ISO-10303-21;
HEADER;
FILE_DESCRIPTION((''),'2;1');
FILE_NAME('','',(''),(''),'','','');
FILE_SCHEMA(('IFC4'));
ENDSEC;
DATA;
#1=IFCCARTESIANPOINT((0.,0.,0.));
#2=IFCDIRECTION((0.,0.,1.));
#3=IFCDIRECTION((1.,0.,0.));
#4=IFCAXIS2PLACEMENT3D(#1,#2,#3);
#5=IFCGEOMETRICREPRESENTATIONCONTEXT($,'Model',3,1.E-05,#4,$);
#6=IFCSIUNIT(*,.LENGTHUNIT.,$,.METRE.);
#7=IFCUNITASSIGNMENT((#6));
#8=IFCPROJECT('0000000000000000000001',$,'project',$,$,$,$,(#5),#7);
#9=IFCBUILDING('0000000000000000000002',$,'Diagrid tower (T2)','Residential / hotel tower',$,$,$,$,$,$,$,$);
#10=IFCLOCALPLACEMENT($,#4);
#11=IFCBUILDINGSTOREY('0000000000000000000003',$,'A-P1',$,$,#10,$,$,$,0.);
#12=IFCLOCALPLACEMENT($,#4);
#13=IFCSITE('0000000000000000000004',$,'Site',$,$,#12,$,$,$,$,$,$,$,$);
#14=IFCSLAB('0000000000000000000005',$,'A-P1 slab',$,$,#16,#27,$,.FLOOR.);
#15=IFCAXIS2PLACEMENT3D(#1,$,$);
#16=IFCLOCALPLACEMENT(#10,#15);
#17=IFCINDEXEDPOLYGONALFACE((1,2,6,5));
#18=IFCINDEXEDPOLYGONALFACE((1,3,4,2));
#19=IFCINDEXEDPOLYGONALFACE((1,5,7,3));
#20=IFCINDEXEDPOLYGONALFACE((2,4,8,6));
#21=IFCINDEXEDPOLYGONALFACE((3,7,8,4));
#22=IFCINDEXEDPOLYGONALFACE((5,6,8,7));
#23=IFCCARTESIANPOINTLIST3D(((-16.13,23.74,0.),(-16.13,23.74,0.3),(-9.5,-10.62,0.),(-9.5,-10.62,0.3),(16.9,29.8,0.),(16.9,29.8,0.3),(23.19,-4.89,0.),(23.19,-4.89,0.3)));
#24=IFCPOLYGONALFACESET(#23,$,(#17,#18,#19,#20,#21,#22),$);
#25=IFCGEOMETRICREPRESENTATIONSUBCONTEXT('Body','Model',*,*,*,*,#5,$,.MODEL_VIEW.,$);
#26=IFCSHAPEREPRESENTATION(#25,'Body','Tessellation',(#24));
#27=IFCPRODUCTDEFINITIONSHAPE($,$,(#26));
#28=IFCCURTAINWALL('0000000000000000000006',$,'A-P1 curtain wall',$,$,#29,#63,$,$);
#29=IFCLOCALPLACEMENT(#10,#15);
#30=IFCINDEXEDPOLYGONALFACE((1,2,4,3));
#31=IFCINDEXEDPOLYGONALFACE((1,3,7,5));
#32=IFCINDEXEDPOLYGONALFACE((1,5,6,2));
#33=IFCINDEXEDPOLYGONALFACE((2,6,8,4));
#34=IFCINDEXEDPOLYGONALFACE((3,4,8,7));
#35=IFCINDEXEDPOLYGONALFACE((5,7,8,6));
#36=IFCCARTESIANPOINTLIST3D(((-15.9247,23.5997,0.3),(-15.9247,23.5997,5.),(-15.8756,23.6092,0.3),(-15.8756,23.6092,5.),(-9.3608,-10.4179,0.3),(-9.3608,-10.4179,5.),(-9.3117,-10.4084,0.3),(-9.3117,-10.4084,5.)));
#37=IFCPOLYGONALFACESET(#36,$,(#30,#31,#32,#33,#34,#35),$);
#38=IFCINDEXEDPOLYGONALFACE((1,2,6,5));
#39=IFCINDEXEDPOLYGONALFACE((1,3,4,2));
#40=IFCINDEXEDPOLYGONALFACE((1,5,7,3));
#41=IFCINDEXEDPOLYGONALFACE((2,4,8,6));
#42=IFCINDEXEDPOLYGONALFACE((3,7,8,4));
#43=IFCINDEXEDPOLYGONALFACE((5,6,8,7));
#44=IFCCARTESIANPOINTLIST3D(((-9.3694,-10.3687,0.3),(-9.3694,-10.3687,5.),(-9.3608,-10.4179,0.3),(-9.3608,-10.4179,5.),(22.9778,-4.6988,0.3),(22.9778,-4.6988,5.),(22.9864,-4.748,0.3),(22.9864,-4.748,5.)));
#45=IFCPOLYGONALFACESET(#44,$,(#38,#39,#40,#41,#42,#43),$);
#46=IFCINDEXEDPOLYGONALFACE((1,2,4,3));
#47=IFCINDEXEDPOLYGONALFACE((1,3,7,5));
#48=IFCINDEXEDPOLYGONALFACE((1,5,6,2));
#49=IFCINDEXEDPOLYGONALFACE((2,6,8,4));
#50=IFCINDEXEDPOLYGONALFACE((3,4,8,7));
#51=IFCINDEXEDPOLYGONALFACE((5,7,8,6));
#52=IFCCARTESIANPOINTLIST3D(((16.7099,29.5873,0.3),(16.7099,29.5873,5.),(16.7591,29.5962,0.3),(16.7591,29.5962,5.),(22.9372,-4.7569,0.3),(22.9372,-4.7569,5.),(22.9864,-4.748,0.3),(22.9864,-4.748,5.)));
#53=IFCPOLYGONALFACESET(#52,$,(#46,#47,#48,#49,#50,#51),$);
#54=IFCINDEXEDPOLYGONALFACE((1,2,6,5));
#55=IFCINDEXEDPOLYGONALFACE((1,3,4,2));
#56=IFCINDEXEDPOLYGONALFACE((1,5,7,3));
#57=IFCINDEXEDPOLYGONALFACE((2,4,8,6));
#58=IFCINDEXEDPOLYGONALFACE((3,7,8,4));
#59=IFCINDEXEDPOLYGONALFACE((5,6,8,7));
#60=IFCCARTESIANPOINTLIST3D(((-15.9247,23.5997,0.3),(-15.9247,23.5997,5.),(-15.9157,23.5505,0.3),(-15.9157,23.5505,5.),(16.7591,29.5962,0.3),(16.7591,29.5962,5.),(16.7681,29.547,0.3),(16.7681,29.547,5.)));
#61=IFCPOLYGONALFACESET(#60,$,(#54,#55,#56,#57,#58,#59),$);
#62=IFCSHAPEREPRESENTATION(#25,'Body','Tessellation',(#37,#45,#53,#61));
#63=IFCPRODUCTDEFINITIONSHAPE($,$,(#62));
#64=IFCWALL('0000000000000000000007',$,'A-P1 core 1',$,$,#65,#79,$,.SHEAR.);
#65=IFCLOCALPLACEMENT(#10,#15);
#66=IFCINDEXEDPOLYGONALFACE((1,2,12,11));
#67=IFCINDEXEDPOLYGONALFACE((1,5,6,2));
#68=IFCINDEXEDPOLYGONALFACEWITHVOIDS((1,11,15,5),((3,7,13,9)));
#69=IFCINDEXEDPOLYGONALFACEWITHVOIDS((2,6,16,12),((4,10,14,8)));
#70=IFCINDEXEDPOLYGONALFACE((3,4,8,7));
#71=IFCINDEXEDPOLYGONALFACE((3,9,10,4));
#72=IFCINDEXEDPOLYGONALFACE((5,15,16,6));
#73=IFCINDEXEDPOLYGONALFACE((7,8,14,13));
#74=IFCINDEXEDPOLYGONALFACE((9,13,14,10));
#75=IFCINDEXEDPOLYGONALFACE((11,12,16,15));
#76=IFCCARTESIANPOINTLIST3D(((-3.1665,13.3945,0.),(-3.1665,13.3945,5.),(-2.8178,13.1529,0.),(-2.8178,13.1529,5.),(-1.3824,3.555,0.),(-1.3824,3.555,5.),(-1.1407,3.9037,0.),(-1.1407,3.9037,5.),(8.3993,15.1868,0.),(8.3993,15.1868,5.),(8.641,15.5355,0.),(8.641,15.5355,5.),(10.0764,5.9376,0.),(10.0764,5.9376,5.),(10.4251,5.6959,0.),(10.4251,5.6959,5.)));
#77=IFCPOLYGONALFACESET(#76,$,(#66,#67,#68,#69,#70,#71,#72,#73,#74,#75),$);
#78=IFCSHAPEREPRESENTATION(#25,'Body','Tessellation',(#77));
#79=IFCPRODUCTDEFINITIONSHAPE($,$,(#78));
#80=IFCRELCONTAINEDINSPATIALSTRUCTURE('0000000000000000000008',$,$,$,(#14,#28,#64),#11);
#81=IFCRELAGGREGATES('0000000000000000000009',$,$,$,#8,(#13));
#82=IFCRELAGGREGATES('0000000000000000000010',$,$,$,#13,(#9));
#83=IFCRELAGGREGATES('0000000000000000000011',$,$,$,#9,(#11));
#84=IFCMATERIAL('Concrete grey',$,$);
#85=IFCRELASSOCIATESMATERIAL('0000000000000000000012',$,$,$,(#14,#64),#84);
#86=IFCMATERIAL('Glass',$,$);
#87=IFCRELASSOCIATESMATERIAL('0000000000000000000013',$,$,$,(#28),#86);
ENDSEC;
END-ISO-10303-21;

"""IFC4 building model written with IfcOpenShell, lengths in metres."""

from ifc_helpers import new_model, si_unit, frame, origin_with_axes, place, context, subcontext, project, spatial, polyline, outline, extrude, material, element, save


model = new_model("IFC4")

# Units and contexts
model_context = context("Model", 3, precision=1e-05, world=origin_with_axes())
body_context = subcontext(model_context, "Body", "Model", "MODEL_VIEW")
ifc_project = project(units=[si_unit("LENGTHUNIT", "METRE")], contexts=[model_context])

# Site, building, storey
site_placement = place(None, origin_with_axes())
site = spatial("IfcSite", under=ifc_project, at=site_placement, Name="Site")
building = spatial("IfcBuilding", under=site, Name="Diagrid tower (T2)", Description="Residential / hotel tower")
storey_placement = place(None, origin_with_axes())
storey = spatial("IfcBuildingStorey", under=building, at=storey_placement, Name="A-P1", Elevation=0.0)

# Slab
ifc_material_1 = material(Name="Concrete grey")
slab_placement = place(storey_placement, origin_with_axes())
element("IfcSlab", 1, at=slab_placement, inside=storey, material=ifc_material_1, Name="A-P1 slab", PredefinedType="FLOOR", context=body_context, shape_type="SweptSolid", body=[
    extrude(outline(polyline([(-16.13, 23.74), (-9.5, -10.62), (23.19, -4.89), (16.9, 29.8), (-16.13, 23.74)])), origin_with_axes(), (0.0, 0.0, 1.0), 0.3),
])

# Curtain wall
ifc_material_2 = material(Name="Glass")
curtain_wall_placement = place(storey_placement, origin_with_axes())
element("IfcCurtainWall", 2, at=curtain_wall_placement, inside=storey, material=ifc_material_2, Name="A-P1 curtain wall", context=body_context, shape_type="SweptSolid", body=[
    extrude(outline(polyline([(-15.9247, 23.5997), (-9.3608, -10.4179), (-9.3117, -10.4084), (-15.8756, 23.6092), (-15.9247, 23.5997)])), frame((0.0, 0.0, 0.3), z_axis=(0.0, 0.0, 1.0), x_axis=(1.0, 0.0, 0.0)), (0.0, 0.0, 1.0), 4.7),
    extrude(outline(polyline([(-9.3608, -10.4179), (22.9864, -4.748), (22.9778, -4.6988), (-9.3694, -10.3687), (-9.3608, -10.4179)])), frame((0.0, 0.0, 0.3), z_axis=(0.0, 0.0, 1.0), x_axis=(1.0, 0.0, 0.0)), (0.0, 0.0, 1.0), 4.7),
    extrude(outline(polyline([(22.9864, -4.748), (16.7591, 29.5962), (16.7099, 29.5873), (22.9372, -4.7569), (22.9864, -4.748)])), frame((0.0, 0.0, 0.3), z_axis=(0.0, 0.0, 1.0), x_axis=(1.0, 0.0, 0.0)), (0.0, 0.0, 1.0), 4.7),
    extrude(outline(polyline([(16.7591, 29.5962), (-15.9247, 23.5997), (-15.9157, 23.5505), (16.7681, 29.547), (16.7591, 29.5962)])), frame((0.0, 0.0, 0.3), z_axis=(0.0, 0.0, 1.0), x_axis=(1.0, 0.0, 0.0)), (0.0, 0.0, 1.0), 4.7),
])

# Wall
wall_placement = place(storey_placement, origin_with_axes())
element("IfcWall", 3, at=wall_placement, inside=storey, material=ifc_material_1, Name="A-P1 core 1", PredefinedType="SHEAR", context=body_context, shape_type="SweptSolid", body=[
    extrude(outline(polyline([(10.4251, 5.6959), (8.641, 15.5355), (-3.1665, 13.3945), (-1.3824, 3.555), (10.4251, 5.6959)]), holes=[polyline([(10.0764, 5.9376), (8.3993, 15.1868), (-2.8178, 13.1529), (-1.1407, 3.9037), (10.0764, 5.9376)])]), origin_with_axes(), (0.0, 0.0, 1.0), 5.0),
])

save(model, "model.ifc")
